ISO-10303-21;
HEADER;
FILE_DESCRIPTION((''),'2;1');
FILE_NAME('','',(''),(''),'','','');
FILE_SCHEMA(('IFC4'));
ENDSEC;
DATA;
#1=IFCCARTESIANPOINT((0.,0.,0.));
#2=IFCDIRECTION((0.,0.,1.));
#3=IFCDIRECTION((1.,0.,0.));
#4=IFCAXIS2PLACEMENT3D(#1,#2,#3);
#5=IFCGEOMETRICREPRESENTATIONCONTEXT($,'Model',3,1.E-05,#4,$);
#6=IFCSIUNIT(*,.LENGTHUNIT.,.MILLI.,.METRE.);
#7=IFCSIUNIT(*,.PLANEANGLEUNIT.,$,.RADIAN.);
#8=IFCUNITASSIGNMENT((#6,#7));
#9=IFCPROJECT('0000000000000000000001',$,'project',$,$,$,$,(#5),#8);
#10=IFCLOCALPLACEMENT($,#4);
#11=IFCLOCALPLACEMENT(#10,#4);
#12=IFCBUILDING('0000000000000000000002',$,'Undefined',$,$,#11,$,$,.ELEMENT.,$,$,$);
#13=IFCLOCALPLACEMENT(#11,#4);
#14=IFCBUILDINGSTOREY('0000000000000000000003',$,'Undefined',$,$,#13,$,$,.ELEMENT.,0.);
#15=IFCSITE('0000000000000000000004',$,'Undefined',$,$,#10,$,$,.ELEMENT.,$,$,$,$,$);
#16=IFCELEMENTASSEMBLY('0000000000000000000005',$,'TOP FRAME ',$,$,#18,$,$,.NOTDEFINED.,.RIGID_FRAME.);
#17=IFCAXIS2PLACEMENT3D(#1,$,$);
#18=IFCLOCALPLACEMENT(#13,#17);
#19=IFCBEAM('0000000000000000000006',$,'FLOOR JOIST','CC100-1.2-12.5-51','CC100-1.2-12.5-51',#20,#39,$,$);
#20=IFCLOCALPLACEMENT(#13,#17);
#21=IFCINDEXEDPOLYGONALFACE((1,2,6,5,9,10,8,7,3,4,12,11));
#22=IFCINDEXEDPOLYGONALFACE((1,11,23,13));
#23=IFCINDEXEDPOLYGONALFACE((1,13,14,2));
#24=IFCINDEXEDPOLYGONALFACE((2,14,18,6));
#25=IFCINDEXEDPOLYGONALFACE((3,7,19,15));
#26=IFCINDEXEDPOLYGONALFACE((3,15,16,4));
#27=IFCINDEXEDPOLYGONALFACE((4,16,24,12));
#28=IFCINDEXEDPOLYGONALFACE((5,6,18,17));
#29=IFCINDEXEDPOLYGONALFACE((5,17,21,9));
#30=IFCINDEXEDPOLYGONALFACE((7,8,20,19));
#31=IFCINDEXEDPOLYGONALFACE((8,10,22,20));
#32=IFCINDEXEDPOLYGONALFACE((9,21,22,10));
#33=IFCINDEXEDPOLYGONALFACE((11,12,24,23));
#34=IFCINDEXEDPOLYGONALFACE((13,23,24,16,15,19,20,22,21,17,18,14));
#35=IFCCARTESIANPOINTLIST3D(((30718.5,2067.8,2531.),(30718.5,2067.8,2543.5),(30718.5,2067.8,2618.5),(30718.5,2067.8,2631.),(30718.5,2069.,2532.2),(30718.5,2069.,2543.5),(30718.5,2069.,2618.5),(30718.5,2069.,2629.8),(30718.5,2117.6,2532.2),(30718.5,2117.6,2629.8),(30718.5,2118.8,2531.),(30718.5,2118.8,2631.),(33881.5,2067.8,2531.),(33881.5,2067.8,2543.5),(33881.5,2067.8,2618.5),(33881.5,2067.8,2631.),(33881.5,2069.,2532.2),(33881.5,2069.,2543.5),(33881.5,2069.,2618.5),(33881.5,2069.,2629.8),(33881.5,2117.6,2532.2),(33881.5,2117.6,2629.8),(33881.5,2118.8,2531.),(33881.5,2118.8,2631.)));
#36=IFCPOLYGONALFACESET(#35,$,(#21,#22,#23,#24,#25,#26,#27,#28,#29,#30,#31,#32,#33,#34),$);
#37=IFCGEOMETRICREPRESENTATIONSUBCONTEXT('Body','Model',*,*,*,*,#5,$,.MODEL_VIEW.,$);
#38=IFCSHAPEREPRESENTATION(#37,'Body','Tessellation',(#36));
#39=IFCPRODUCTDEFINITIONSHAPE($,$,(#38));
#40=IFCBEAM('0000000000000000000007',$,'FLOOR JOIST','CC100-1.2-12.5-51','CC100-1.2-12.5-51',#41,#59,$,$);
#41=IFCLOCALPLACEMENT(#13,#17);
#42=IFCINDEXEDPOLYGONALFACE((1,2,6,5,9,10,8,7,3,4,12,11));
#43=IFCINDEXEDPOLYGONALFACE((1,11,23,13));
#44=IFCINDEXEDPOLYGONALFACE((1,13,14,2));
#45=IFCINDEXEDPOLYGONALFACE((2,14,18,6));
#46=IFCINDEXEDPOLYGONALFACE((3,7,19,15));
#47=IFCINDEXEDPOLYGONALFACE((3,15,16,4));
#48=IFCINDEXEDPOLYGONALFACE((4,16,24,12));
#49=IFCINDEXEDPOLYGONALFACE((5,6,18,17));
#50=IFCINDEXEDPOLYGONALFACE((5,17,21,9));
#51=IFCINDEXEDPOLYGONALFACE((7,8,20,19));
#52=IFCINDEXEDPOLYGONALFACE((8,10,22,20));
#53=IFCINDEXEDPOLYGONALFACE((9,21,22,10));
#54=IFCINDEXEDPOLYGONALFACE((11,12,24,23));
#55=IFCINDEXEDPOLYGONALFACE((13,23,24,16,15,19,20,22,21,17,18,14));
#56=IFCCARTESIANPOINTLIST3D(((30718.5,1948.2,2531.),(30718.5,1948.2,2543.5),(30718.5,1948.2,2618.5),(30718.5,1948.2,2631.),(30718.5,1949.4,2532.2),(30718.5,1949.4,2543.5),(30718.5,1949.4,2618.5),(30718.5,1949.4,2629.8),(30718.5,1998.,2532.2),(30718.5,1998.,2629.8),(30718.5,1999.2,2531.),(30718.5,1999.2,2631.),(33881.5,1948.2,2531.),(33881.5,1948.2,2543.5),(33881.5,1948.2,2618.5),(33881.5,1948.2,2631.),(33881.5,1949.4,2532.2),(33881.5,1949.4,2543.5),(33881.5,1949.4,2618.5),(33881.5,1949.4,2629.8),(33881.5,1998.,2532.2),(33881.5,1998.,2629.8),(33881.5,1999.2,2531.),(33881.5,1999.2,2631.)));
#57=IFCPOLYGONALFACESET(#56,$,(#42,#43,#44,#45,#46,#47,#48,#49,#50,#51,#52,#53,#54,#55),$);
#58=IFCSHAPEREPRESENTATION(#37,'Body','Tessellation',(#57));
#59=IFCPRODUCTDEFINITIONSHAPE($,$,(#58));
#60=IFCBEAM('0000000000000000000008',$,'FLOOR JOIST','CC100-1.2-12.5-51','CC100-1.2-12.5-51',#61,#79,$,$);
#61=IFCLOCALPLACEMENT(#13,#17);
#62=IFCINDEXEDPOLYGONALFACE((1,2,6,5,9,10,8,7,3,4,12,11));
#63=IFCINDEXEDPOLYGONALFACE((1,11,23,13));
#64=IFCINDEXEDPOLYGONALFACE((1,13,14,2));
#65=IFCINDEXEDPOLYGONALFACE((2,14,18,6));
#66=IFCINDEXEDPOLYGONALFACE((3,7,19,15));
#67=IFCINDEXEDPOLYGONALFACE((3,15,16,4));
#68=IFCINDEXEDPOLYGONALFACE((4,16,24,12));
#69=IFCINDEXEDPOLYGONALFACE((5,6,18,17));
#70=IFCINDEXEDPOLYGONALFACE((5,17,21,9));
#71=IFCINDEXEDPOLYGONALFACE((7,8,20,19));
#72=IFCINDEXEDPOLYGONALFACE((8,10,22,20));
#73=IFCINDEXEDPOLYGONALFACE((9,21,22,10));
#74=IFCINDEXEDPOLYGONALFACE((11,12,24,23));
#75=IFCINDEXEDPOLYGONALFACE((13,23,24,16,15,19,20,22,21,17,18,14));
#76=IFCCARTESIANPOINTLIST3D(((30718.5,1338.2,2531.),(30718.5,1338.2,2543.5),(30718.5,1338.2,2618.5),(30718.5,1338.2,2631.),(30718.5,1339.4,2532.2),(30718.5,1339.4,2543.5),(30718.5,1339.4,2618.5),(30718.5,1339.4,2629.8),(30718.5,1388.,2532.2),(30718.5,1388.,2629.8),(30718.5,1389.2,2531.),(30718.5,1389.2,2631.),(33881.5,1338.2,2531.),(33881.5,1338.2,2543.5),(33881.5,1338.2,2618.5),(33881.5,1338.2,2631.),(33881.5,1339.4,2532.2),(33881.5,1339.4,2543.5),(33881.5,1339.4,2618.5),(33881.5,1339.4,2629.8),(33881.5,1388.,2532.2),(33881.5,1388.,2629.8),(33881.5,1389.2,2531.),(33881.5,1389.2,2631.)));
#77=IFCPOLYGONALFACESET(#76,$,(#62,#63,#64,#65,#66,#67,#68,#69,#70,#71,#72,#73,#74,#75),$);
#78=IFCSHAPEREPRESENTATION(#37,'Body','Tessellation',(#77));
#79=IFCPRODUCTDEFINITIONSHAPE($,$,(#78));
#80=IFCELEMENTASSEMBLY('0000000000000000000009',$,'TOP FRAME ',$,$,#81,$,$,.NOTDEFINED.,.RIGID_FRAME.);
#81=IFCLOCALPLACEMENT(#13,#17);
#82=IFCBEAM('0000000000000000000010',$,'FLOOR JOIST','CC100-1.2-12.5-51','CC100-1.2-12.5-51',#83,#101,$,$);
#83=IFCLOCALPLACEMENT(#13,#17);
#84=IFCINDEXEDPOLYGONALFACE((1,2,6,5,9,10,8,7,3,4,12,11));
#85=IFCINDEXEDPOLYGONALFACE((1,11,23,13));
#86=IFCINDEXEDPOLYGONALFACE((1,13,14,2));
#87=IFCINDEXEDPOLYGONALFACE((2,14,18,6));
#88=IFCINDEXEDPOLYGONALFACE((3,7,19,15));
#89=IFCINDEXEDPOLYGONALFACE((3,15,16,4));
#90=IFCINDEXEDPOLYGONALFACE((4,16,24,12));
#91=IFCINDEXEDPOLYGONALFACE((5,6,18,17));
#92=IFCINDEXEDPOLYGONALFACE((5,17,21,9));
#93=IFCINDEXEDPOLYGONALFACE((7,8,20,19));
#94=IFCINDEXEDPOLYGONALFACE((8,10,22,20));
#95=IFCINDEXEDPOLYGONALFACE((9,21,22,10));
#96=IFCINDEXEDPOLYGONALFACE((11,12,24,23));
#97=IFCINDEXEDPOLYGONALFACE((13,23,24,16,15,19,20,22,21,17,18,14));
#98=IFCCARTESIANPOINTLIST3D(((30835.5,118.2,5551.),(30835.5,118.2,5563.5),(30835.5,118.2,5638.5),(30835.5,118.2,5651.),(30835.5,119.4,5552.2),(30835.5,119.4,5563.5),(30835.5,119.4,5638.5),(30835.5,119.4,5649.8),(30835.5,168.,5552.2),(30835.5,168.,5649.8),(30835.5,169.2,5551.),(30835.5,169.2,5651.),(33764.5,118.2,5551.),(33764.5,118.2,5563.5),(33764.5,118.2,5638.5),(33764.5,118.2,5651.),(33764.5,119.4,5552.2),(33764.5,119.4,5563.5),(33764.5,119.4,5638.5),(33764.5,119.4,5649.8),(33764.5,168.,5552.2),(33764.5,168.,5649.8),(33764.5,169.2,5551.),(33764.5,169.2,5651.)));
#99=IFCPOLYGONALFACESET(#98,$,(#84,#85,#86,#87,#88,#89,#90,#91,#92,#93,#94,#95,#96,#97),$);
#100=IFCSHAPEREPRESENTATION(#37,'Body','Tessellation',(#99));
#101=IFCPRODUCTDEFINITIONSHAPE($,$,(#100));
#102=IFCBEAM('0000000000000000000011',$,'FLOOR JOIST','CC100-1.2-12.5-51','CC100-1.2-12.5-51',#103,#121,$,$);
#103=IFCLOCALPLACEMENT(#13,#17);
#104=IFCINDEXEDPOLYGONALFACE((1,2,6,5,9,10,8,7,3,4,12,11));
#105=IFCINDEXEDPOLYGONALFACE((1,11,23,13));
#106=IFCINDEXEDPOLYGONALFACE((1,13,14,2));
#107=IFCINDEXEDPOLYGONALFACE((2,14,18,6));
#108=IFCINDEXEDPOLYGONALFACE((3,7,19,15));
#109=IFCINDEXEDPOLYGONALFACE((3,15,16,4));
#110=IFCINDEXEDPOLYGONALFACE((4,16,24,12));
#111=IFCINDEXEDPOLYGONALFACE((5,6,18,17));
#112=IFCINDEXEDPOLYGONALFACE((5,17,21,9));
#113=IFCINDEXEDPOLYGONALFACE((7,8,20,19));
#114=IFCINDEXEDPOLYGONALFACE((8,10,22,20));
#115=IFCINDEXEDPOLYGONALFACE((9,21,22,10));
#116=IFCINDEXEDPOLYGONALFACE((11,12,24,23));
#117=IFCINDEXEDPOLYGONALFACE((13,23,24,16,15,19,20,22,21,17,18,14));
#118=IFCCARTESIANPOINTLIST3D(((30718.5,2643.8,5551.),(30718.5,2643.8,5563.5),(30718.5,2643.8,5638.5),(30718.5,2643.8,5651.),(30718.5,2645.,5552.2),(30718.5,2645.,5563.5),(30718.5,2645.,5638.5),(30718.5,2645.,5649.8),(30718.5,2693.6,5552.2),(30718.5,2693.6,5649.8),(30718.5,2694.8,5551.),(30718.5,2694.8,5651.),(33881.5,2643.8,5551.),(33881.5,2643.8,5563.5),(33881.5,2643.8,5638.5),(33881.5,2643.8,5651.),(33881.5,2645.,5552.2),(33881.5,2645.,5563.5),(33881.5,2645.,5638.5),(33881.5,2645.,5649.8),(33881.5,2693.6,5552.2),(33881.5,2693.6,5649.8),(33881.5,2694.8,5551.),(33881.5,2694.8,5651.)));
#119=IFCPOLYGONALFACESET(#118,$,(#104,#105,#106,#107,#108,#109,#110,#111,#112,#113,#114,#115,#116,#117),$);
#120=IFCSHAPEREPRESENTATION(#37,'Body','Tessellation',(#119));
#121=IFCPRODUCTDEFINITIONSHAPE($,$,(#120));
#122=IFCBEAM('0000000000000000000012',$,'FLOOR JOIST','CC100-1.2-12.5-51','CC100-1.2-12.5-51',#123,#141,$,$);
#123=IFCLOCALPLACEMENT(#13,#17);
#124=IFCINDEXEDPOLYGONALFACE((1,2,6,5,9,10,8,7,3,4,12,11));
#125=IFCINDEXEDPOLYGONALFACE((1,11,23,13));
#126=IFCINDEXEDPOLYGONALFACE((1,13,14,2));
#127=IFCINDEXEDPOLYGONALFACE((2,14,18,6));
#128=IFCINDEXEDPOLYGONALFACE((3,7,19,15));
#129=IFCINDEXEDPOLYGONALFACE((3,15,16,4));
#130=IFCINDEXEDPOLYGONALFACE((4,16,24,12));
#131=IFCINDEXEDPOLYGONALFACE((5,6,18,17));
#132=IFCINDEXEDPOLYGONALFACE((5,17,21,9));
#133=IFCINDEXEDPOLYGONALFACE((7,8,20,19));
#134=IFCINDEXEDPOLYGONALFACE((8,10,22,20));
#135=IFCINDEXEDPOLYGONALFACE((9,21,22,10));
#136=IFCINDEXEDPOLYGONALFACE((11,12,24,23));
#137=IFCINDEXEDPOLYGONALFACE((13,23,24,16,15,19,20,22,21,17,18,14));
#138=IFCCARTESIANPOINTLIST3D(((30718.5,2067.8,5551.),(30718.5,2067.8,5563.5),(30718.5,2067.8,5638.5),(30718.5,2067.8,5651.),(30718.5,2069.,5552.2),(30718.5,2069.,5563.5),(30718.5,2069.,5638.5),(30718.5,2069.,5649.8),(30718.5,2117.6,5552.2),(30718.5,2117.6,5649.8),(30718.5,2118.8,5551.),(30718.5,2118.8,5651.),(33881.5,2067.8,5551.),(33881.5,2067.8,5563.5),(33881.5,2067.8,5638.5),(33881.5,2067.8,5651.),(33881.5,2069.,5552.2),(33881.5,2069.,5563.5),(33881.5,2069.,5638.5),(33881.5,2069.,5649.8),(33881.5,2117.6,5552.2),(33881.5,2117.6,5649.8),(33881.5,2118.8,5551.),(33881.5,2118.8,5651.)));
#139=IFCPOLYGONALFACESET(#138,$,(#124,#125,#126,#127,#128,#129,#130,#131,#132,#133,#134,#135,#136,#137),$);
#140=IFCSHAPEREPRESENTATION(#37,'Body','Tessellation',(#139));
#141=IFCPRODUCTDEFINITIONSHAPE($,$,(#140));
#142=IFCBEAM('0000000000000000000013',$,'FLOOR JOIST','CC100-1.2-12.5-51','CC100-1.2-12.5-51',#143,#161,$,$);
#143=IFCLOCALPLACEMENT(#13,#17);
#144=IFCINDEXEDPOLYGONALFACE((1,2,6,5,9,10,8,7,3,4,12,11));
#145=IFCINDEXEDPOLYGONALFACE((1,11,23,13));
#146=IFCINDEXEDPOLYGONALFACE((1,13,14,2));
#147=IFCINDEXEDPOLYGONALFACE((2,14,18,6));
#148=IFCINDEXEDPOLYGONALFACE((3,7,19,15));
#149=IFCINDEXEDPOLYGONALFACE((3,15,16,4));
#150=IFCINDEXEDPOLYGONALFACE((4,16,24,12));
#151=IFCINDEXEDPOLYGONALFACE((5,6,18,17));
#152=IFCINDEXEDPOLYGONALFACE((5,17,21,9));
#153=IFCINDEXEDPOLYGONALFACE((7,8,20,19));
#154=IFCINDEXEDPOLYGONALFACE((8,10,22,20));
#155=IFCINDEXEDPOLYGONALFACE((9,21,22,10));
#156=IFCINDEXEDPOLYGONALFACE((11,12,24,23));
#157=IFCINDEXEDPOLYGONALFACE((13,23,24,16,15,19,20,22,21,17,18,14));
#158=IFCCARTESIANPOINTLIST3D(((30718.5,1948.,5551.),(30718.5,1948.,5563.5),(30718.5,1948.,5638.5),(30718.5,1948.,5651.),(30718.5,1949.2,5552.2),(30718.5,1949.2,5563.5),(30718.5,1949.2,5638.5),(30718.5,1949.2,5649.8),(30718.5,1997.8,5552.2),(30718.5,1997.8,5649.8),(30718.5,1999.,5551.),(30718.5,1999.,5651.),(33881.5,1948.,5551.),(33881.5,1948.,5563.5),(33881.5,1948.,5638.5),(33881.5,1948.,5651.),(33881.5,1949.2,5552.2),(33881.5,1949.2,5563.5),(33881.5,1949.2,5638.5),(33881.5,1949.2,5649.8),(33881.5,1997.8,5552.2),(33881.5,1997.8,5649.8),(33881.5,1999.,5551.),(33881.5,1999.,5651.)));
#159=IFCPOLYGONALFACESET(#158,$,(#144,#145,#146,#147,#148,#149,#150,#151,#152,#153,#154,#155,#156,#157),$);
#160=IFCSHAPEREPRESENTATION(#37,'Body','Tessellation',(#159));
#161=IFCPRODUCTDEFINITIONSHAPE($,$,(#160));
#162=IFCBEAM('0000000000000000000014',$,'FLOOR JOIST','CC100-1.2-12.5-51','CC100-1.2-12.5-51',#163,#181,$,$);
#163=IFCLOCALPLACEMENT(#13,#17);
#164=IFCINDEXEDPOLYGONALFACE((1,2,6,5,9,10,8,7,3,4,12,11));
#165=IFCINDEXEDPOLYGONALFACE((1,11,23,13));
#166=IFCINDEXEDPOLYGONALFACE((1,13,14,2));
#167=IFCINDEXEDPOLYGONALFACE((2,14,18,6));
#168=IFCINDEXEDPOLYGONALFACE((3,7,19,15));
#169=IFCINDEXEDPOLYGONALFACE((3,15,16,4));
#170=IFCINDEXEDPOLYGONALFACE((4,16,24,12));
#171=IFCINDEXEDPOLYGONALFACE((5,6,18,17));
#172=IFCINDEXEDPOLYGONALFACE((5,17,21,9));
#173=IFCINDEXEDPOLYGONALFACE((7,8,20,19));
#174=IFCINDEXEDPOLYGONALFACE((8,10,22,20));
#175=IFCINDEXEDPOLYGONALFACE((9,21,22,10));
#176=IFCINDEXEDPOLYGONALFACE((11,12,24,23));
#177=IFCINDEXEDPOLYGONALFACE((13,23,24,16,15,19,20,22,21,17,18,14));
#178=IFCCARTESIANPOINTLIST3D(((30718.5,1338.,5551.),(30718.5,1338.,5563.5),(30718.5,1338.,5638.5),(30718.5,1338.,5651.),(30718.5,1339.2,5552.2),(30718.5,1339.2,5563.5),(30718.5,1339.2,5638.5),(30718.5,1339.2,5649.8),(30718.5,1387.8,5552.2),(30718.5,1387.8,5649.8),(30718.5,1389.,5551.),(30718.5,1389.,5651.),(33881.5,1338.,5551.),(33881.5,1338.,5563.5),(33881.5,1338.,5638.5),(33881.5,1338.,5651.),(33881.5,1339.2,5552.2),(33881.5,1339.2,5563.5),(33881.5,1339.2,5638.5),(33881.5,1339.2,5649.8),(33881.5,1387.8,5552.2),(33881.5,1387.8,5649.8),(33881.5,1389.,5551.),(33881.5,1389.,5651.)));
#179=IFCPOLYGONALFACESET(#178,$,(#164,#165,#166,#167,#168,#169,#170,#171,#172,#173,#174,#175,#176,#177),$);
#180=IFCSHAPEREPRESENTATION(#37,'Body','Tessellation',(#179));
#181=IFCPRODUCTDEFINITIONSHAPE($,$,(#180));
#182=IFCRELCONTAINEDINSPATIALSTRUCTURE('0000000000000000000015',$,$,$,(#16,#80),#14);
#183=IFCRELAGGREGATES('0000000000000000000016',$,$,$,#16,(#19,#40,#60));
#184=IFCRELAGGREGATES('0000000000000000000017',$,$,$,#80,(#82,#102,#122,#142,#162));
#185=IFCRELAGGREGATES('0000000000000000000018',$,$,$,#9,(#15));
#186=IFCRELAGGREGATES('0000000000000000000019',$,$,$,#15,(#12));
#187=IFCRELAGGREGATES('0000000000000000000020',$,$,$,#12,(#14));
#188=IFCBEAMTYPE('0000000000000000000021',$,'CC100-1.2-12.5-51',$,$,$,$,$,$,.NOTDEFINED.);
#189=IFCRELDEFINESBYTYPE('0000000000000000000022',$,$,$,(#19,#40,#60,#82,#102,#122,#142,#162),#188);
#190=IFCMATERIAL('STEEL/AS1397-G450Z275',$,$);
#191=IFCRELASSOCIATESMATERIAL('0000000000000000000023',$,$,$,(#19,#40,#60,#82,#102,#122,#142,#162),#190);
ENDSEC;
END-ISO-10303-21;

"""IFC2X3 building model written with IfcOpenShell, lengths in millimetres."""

from ifc_helpers import new_model, si_unit, frame, origin_with_axes, origin_2d_with_axis, place, context, subcontext, project, spatial, c_section, extrude, material, type_object, element, aggregate, save


model = new_model("IFC2X3")

# Units and contexts
model_context = context("Model", 3, precision=1e-05, world=origin_with_axes())
body_context = subcontext(model_context, "Body", "Model", "MODEL_VIEW")
ifc_project = project(units=[si_unit("LENGTHUNIT", "METRE", prefix="MILLI"), si_unit("PLANEANGLEUNIT", "RADIAN")], contexts=[model_context])

# Site, building, storey
site_placement = place(None, origin_with_axes())
site = spatial("IfcSite", under=ifc_project, at=site_placement, Name="Undefined", CompositionType="ELEMENT")
building_placement = place(site_placement, origin_with_axes())
building = spatial("IfcBuilding", under=site, at=building_placement, Name="Undefined", CompositionType="ELEMENT")
storey_placement = place(building_placement, origin_with_axes())
storey = spatial("IfcBuildingStorey", under=building, at=storey_placement, Name="Undefined", CompositionType="ELEMENT", Elevation=0.0)

# Element assemblies, beams
ifc_material_1 = material(Name="STEEL/AS1397-G450Z275")
assembly_1_placement = place(storey_placement, origin_with_axes())
assembly_1 = element("IfcElementAssembly", 1, at=assembly_1_placement, inside=storey, Name="TOP FRAME ", AssemblyPlace="NOTDEFINED", PredefinedType="RIGID_FRAME")
beam_type_1 = type_object("IfcBeamType", Name="CC100-1.2-12.5-51", PredefinedType="NOTDEFINED")
beam_1_placement = place(assembly_1_placement, frame((30718.5, 2093.3, 2581.0), z_axis=(0.0, 0.0, 1.0), x_axis=(1.0, 0.0, 0.0)))
beam_1 = element("IfcBeam", 2, at=beam_1_placement, type_object=beam_type_1, material=ifc_material_1, Name="FLOOR JOIST", Description="CC100-1.2-12.5-51", ObjectType="CC100-1.2-12.5-51", context=body_context, shape_type="SweptSolid", body=[
    extrude(c_section(Depth=100.0, Width=51.0, WallThickness=1.2, Girth=12.5, at=origin_2d_with_axis()), frame((3163.0, 0.0, 0.0), z_axis=(-1.0, 0.0, 0.0), x_axis=(0.0, -1.0, 0.0)), (0.0, 0.0, 1.0), 3163.0),
])
beam_2_placement = place(assembly_1_placement, frame((30718.5, 1973.7, 2581.0), z_axis=(0.0, 0.0, 1.0), x_axis=(1.0, 0.0, 0.0)))
beam_2 = element("IfcBeam", 3, at=beam_2_placement, type_object=beam_type_1, material=ifc_material_1, Name="FLOOR JOIST", Description="CC100-1.2-12.5-51", ObjectType="CC100-1.2-12.5-51", context=body_context, shape_type="SweptSolid", body=[
    extrude(c_section(Depth=100.0, Width=51.0, WallThickness=1.2, Girth=12.5, at=origin_2d_with_axis()), frame((3163.0, 0.0, 0.0), z_axis=(-1.0, 0.0, 0.0), x_axis=(0.0, -1.0, 0.0)), (0.0, 0.0, 1.0), 3163.0),
])
beam_3_placement = place(assembly_1_placement, frame((30718.5, 1363.7, 2581.0), z_axis=(0.0, 0.0, 1.0), x_axis=(1.0, 0.0, 0.0)))
beam_3 = element("IfcBeam", 4, at=beam_3_placement, type_object=beam_type_1, material=ifc_material_1, Name="FLOOR JOIST", Description="CC100-1.2-12.5-51", ObjectType="CC100-1.2-12.5-51", context=body_context, shape_type="SweptSolid", body=[
    extrude(c_section(Depth=100.0, Width=51.0, WallThickness=1.2, Girth=12.5, at=origin_2d_with_axis()), frame((3163.0, 0.0, 0.0), z_axis=(-1.0, 0.0, 0.0), x_axis=(0.0, -1.0, 0.0)), (0.0, 0.0, 1.0), 3163.0),
])
aggregate(assembly_1, [beam_1, beam_2, beam_3])
assembly_2_placement = place(storey_placement, origin_with_axes())
assembly_2 = element("IfcElementAssembly", 5, at=assembly_2_placement, inside=storey, Name="TOP FRAME ", AssemblyPlace="NOTDEFINED", PredefinedType="RIGID_FRAME")
beam_4_placement = place(assembly_2_placement, frame((30835.5, 143.7, 5601.0), z_axis=(0.0, 0.0, 1.0), x_axis=(1.0, 0.0, 0.0)))
beam_4 = element("IfcBeam", 6, at=beam_4_placement, type_object=beam_type_1, material=ifc_material_1, Name="FLOOR JOIST", Description="CC100-1.2-12.5-51", ObjectType="CC100-1.2-12.5-51", context=body_context, shape_type="SweptSolid", body=[
    extrude(c_section(Depth=100.0, Width=51.0, WallThickness=1.2, Girth=12.5, at=origin_2d_with_axis()), frame((2929.0, 0.0, 0.0), z_axis=(-1.0, 0.0, 0.0), x_axis=(0.0, -1.0, 0.0)), (0.0, 0.0, 1.0), 2929.0),
])
beam_5_placement = place(assembly_2_placement, frame((30718.5, 2669.3, 5601.0), z_axis=(0.0, 0.0, 1.0), x_axis=(1.0, 0.0, 0.0)))
beam_5 = element("IfcBeam", 7, at=beam_5_placement, type_object=beam_type_1, material=ifc_material_1, Name="FLOOR JOIST", Description="CC100-1.2-12.5-51", ObjectType="CC100-1.2-12.5-51", context=body_context, shape_type="SweptSolid", body=[
    extrude(c_section(Depth=100.0, Width=51.0, WallThickness=1.2, Girth=12.5, at=origin_2d_with_axis()), frame((3163.0, 0.0, 0.0), z_axis=(-1.0, 0.0, 0.0), x_axis=(0.0, -1.0, 0.0)), (0.0, 0.0, 1.0), 3163.0),
])
beam_6_placement = place(assembly_2_placement, frame((30718.5, 2093.3, 5601.0), z_axis=(0.0, 0.0, 1.0), x_axis=(1.0, 0.0, 0.0)))
beam_6 = element("IfcBeam", 8, at=beam_6_placement, type_object=beam_type_1, material=ifc_material_1, Name="FLOOR JOIST", Description="CC100-1.2-12.5-51", ObjectType="CC100-1.2-12.5-51", context=body_context, shape_type="SweptSolid", body=[
    extrude(c_section(Depth=100.0, Width=51.0, WallThickness=1.2, Girth=12.5, at=origin_2d_with_axis()), frame((3163.0, 0.0, 0.0), z_axis=(-1.0, 0.0, 0.0), x_axis=(0.0, -1.0, 0.0)), (0.0, 0.0, 1.0), 3163.0),
])
beam_7_placement = place(assembly_2_placement, frame((30718.5, 1973.5, 5601.0), z_axis=(0.0, 0.0, 1.0), x_axis=(1.0, 0.0, 0.0)))
beam_7 = element("IfcBeam", 9, at=beam_7_placement, type_object=beam_type_1, material=ifc_material_1, Name="FLOOR JOIST", Description="CC100-1.2-12.5-51", ObjectType="CC100-1.2-12.5-51", context=body_context, shape_type="SweptSolid", body=[
    extrude(c_section(Depth=100.0, Width=51.0, WallThickness=1.2, Girth=12.5, at=origin_2d_with_axis()), frame((3163.0, 0.0, 0.0), z_axis=(-1.0, 0.0, 0.0), x_axis=(0.0, -1.0, 0.0)), (0.0, 0.0, 1.0), 3163.0),
])
beam_8_placement = place(assembly_2_placement, frame((30718.5, 1363.5, 5601.0), z_axis=(0.0, 0.0, 1.0), x_axis=(1.0, 0.0, 0.0)))
beam_8 = element("IfcBeam", 10, at=beam_8_placement, type_object=beam_type_1, material=ifc_material_1, Name="FLOOR JOIST", Description="CC100-1.2-12.5-51", ObjectType="CC100-1.2-12.5-51", context=body_context, shape_type="SweptSolid", body=[
    extrude(c_section(Depth=100.0, Width=51.0, WallThickness=1.2, Girth=12.5, at=origin_2d_with_axis()), frame((3163.0, 0.0, 0.0), z_axis=(-1.0, 0.0, 0.0), x_axis=(0.0, -1.0, 0.0)), (0.0, 0.0, 1.0), 3163.0),
])
aggregate(assembly_2, [beam_4, beam_5, beam_6, beam_7, beam_8])

save(model, "model.ifc")
